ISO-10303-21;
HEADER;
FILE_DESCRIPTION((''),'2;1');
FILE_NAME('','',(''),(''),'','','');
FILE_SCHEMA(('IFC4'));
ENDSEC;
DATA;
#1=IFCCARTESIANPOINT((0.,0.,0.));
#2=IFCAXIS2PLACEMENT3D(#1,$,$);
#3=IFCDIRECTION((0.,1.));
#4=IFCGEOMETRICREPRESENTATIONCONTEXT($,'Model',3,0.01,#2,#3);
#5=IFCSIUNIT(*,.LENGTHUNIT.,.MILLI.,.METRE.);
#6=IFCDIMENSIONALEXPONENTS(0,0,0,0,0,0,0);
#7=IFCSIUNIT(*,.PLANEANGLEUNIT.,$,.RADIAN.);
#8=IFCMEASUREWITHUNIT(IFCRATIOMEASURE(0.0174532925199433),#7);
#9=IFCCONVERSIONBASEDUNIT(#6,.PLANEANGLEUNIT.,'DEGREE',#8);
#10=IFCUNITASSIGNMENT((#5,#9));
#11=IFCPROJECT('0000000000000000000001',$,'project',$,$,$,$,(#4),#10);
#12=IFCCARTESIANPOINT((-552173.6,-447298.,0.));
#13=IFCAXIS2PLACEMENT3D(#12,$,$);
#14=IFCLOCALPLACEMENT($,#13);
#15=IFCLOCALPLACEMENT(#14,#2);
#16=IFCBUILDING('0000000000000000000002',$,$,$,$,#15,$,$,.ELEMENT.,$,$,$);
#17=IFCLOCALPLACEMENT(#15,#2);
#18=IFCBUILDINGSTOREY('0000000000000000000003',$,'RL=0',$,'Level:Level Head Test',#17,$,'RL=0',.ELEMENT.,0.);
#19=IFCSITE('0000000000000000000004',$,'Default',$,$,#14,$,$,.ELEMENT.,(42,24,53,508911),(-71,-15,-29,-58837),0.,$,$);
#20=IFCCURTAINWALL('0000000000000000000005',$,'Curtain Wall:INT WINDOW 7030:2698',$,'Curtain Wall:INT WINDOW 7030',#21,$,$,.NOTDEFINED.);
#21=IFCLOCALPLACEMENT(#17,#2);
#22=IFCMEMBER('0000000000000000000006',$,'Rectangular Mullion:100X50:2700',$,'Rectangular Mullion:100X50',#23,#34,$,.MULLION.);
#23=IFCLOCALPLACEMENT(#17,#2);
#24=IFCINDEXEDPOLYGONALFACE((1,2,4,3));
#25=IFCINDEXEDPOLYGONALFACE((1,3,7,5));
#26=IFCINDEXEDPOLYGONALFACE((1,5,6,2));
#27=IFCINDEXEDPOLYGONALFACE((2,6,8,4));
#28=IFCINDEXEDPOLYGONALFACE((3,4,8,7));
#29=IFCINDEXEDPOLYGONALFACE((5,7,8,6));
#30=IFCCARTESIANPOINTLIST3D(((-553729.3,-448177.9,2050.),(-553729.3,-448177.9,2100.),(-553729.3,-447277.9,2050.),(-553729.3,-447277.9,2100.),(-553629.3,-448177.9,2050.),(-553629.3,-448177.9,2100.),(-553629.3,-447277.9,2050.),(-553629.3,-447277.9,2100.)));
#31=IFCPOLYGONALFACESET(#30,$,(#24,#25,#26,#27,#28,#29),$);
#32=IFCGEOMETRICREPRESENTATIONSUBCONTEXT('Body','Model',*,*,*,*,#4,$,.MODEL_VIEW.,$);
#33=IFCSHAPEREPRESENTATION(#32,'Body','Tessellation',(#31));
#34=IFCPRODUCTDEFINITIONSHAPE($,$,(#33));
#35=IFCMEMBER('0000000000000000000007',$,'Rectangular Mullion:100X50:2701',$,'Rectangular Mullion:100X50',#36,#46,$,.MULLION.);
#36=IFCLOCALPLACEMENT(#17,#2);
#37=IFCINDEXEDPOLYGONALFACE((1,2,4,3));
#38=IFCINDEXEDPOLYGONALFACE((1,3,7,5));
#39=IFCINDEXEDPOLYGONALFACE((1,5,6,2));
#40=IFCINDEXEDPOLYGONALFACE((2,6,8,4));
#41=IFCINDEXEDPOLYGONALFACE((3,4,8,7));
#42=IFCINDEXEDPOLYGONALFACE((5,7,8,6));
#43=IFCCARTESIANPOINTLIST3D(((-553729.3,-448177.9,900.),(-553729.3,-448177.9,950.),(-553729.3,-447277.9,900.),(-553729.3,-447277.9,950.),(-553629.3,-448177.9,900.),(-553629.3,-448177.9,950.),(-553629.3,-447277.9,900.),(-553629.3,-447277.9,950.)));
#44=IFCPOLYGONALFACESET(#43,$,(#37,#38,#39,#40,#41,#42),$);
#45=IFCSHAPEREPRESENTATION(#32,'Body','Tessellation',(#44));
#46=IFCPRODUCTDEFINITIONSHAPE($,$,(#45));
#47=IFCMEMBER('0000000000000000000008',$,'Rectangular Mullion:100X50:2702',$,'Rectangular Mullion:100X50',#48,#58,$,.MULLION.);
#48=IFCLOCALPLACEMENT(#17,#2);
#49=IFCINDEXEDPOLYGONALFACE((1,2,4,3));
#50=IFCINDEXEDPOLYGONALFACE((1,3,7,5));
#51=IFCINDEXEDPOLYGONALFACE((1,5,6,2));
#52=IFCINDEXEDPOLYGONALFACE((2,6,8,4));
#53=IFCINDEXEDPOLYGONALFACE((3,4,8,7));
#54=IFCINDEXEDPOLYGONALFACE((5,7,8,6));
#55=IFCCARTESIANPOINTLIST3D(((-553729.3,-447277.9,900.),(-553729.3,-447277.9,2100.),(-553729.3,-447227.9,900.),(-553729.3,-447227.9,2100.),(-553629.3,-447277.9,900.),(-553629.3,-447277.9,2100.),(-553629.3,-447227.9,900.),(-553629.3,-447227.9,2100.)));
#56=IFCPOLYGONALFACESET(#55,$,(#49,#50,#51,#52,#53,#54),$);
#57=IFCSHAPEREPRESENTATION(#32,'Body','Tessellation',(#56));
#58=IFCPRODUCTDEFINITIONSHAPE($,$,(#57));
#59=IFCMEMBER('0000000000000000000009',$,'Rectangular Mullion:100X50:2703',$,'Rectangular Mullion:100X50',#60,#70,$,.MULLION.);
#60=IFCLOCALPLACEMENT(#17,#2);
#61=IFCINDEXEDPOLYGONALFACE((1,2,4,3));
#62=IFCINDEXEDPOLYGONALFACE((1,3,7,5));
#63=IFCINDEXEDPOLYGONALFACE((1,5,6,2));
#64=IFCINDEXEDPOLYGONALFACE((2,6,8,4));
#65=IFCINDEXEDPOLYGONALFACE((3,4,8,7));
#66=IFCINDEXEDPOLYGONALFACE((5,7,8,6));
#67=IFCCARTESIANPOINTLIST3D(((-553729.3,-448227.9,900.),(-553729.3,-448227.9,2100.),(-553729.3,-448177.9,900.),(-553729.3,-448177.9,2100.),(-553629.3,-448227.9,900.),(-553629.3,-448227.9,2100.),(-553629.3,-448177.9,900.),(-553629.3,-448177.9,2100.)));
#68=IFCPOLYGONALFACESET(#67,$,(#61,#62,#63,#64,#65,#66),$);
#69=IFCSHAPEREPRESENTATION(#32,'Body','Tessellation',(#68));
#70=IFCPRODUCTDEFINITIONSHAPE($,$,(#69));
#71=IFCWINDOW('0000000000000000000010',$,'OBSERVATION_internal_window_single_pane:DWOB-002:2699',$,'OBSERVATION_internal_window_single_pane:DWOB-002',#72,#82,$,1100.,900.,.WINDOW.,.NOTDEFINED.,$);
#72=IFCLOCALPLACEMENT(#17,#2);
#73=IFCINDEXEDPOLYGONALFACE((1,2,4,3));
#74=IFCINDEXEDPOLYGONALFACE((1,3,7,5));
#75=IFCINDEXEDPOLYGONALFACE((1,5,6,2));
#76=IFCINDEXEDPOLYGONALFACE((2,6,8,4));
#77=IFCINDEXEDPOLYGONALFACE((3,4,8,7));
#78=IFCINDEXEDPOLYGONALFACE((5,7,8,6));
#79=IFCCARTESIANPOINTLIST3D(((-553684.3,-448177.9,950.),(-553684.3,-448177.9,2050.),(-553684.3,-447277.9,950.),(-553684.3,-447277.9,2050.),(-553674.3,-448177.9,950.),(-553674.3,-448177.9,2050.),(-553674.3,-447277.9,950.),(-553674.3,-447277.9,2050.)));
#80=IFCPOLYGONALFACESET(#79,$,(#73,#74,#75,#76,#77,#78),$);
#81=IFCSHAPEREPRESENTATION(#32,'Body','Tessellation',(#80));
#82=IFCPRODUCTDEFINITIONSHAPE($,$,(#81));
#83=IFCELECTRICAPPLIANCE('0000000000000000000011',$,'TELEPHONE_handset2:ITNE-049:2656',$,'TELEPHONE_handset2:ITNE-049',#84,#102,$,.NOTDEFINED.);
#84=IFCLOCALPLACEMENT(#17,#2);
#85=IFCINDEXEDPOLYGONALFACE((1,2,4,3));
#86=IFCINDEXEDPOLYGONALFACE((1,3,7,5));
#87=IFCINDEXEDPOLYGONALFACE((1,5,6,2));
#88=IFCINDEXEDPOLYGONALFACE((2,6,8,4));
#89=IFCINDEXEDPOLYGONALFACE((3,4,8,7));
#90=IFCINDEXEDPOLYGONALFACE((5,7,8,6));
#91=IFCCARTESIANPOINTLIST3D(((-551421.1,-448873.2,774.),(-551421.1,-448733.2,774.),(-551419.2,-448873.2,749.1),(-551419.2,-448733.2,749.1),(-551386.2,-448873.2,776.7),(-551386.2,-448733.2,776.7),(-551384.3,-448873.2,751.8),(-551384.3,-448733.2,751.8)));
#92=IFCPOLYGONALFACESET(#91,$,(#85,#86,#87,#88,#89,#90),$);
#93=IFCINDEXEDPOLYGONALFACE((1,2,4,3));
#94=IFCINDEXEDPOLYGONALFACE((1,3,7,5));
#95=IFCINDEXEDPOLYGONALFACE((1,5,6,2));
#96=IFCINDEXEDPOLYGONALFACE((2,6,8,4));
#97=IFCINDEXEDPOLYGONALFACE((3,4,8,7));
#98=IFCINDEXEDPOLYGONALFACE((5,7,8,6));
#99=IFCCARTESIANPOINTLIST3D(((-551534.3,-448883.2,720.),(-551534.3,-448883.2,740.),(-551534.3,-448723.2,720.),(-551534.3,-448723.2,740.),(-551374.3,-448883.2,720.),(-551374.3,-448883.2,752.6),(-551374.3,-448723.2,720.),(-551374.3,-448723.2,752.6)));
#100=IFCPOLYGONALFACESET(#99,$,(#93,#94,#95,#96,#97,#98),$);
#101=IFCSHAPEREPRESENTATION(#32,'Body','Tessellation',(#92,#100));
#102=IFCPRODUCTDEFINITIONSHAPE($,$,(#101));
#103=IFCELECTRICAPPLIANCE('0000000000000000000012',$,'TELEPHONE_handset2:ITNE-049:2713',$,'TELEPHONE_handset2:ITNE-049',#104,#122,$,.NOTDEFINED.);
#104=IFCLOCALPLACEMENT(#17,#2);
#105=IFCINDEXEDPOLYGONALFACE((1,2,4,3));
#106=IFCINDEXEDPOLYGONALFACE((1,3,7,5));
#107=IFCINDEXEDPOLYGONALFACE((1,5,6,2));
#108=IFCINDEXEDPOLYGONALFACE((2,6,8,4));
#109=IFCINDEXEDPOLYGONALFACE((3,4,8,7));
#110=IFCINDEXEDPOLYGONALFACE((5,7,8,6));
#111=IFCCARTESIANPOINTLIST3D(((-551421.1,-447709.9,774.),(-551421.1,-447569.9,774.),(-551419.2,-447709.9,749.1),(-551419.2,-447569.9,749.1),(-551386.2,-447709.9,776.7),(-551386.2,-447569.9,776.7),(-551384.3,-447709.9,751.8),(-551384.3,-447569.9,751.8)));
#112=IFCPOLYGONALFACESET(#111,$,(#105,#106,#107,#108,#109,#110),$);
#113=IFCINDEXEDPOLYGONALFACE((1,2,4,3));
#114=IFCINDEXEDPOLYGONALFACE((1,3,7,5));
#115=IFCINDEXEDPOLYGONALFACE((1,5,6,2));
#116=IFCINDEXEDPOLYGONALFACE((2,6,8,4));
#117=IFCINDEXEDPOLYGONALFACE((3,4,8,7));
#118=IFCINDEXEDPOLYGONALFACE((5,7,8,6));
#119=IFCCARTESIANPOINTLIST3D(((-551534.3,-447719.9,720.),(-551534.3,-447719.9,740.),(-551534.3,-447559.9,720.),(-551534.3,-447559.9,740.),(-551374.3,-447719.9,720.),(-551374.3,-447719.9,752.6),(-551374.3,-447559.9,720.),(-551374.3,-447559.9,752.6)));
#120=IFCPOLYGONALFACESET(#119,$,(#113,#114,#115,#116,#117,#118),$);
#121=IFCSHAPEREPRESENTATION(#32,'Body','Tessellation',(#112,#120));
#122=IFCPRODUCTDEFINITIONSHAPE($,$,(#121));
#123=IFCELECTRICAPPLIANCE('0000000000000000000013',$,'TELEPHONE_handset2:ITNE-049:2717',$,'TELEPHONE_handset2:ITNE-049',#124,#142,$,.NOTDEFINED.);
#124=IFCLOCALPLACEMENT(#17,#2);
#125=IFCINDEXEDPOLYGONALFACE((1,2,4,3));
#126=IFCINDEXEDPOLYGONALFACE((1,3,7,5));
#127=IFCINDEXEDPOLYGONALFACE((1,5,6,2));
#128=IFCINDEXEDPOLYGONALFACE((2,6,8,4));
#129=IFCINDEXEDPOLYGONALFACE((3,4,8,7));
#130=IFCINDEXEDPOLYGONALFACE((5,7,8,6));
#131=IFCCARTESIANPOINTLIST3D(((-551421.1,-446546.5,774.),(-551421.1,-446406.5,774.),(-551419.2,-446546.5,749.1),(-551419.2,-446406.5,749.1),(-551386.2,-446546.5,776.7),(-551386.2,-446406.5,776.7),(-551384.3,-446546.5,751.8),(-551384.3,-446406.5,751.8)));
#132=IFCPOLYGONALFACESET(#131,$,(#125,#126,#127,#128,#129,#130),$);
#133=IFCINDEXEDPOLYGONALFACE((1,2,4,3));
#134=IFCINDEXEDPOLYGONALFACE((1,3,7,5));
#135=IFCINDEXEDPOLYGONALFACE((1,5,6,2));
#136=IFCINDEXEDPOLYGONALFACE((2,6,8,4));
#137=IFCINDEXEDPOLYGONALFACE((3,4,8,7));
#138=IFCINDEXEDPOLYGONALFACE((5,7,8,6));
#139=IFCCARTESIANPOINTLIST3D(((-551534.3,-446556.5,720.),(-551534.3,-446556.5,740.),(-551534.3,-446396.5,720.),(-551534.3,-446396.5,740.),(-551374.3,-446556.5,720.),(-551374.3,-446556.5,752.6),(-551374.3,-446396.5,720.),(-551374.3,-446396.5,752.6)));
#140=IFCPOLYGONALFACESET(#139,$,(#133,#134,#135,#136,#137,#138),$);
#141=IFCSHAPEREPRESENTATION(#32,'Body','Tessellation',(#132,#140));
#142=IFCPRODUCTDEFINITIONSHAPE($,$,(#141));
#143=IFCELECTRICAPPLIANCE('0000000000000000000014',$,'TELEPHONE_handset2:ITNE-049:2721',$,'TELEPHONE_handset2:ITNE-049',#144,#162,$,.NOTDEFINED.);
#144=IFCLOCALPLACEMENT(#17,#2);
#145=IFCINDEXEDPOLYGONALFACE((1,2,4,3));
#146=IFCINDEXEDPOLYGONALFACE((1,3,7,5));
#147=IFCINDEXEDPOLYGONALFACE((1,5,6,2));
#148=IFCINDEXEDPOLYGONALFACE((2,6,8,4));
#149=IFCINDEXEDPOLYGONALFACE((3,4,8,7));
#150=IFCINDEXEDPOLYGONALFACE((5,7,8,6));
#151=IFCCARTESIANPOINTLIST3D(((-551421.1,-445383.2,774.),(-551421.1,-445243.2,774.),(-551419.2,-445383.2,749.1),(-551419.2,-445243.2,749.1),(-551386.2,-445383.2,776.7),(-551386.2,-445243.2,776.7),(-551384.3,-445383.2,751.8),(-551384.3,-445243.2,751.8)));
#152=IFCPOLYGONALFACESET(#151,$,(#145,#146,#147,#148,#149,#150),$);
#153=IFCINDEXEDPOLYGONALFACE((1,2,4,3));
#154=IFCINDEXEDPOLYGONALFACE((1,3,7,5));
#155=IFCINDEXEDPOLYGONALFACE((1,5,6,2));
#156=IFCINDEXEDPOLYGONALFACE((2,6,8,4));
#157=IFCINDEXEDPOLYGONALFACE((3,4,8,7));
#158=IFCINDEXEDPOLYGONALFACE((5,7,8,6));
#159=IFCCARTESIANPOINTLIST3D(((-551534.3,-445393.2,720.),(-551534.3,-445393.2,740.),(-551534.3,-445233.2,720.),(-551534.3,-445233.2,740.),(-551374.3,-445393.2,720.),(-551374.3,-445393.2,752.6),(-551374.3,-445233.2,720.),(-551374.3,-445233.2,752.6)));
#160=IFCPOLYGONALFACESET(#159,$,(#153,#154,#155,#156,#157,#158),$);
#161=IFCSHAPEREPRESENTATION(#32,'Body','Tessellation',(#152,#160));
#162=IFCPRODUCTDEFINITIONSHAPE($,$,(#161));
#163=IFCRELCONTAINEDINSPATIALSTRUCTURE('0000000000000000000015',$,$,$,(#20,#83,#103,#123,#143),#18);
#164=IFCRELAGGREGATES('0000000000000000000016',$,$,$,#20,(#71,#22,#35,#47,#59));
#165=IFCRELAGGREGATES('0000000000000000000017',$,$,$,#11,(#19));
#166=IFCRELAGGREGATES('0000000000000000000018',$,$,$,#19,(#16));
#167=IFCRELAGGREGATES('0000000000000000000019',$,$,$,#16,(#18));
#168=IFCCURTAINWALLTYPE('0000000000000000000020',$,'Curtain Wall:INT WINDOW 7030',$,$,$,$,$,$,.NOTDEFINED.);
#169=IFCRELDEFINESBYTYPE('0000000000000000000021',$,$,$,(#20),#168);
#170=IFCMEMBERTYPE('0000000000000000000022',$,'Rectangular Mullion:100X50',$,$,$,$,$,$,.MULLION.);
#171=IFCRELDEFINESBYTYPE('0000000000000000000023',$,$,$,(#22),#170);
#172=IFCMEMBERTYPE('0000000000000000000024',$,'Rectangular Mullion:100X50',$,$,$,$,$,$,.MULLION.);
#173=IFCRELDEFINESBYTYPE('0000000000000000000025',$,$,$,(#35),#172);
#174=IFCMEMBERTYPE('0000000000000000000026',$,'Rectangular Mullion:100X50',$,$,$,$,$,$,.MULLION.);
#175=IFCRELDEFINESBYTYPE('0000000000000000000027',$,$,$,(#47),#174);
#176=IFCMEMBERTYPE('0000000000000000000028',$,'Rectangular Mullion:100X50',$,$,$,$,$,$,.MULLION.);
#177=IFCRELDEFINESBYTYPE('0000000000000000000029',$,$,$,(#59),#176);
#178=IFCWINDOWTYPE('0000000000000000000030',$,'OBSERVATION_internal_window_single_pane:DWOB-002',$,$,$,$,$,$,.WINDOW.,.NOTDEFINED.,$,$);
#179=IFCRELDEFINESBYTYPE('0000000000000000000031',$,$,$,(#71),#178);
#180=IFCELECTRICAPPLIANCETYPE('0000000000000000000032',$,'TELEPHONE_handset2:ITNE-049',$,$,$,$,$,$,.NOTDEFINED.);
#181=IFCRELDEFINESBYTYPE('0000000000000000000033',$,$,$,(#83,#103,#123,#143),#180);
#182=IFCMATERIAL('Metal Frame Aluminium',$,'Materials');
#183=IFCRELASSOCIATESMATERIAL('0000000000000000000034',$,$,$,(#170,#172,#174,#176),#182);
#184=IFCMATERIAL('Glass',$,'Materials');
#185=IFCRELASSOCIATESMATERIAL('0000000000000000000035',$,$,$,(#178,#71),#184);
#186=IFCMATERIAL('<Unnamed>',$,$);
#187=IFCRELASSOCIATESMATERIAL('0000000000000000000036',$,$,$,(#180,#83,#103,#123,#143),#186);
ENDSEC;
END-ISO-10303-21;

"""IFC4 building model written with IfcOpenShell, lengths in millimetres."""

from ifc_helpers import new_model, entity, si_unit, converted_unit, direction, frame, origin, place, context, subcontext, project, spatial, indexed_curve, outline, extrude, source, transform, mapped, material, type_object, type_shapes, element, aggregate, save


model = new_model("IFC4")

# Units and contexts
model_context = context("Model", 3, precision=0.01, world=origin(), true_north=direction((0.0, 1.0)))
body_context = subcontext(model_context, "Body", "Model", "MODEL_VIEW")
ifc_project = project(units=[si_unit("LENGTHUNIT", "METRE", prefix="MILLI"), converted_unit("PLANEANGLEUNIT", "DEGREE", entity("IfcRatioMeasure", 0.0174532925199433), si_unit("PLANEANGLEUNIT", "RADIAN"), dimensions=[0, 0, 0, 0, 0, 0, 0])], contexts=[model_context])

# Site, building, storey
site_placement = place(None, frame((-552173.6, -447298.0, 0.0)))
site = spatial("IfcSite", under=ifc_project, at=site_placement, Name="Default", CompositionType="ELEMENT", RefLatitude=(42, 24, 53, 508911), RefLongitude=(-71, -15, -29, -58837), RefElevation=0.0)
building_placement = place(site_placement, origin())
building = spatial("IfcBuilding", under=site, at=building_placement, CompositionType="ELEMENT")
storey_placement = place(building_placement, origin())
storey = spatial("IfcBuildingStorey", under=building, at=storey_placement, Name="RL=0", ObjectType="Level:Level Head Test", LongName="RL=0", CompositionType="ELEMENT", Elevation=0.0)

# Curtain wall, members
curtain_wall_type = type_object("IfcCurtainWallType", Name="Curtain Wall:INT WINDOW 7030", PredefinedType="NOTDEFINED")
curtain_wall_placement = place(storey_placement, origin())
curtain_wall = element("IfcCurtainWall", 1, at=curtain_wall_placement, inside=storey, type_object=curtain_wall_type, Name="Curtain Wall:INT WINDOW 7030:2698", ObjectType="Curtain Wall:INT WINDOW 7030", PredefinedType="NOTDEFINED")
ifc_material_1 = material(Name="Metal Frame Aluminium", Category="Materials")
member_type_1 = type_object("IfcMemberType", Name="Rectangular Mullion:100X50", PredefinedType="MULLION", material=ifc_material_1)
shared_shape_1 = source(origin(), body_context, "Body", "SweptSolid", [
    extrude(outline(indexed_curve([(-50.0, -25.0), (50.0, -25.0), (50.0, 25.0), (-50.0, 25.0), (-50.0, -25.0)], self_intersect=False)), frame((-25.0, 0.0, -900.0), z_axis=(0.0, 0.0, 1.0), x_axis=(0.0, -1.0, 0.0)), (0.0, 0.0, 1.0), 900.0),
])
type_shapes(member_type_1, [shared_shape_1])
member_1_placement = place(curtain_wall_placement, frame((-553679.3, -447277.9, 2100.0), z_axis=(0.0, 1.0, 0.0), x_axis=(0.0, 0.0, 1.0)))
member_1 = element("IfcMember", 2, at=member_1_placement, type_object=member_type_1, Name="Rectangular Mullion:100X50:2700", ObjectType="Rectangular Mullion:100X50", PredefinedType="MULLION", context=body_context, shape_type="MappedRepresentation", body=[
    mapped(shared_shape_1, transform((0.0, 0.0, 0.0), scale=1.0)),
])
member_type_2 = type_object("IfcMemberType", Name="Rectangular Mullion:100X50", PredefinedType="MULLION", material=ifc_material_1)
shared_shape_2 = source(origin(), body_context, "Body", "SweptSolid", [
    extrude(outline(indexed_curve([(-50.0, -25.0), (50.0, -25.0), (50.0, 25.0), (-50.0, 25.0), (-50.0, -25.0)], self_intersect=False)), frame((-25.0, 0.0, -900.0), z_axis=(0.0, 0.0, 1.0), x_axis=(0.0, -1.0, 0.0)), (0.0, 0.0, 1.0), 900.0),
])
type_shapes(member_type_2, [shared_shape_2])
member_2_placement = place(curtain_wall_placement, frame((-553679.3, -448177.9, 900.0), z_axis=(0.0, -1.0, 0.0), x_axis=(0.0, 0.0, -1.0)))
member_2 = element("IfcMember", 3, at=member_2_placement, type_object=member_type_2, Name="Rectangular Mullion:100X50:2701", ObjectType="Rectangular Mullion:100X50", PredefinedType="MULLION", context=body_context, shape_type="MappedRepresentation", body=[
    mapped(shared_shape_2, transform((0.0, 0.0, 0.0), scale=1.0)),
])
member_type_3 = type_object("IfcMemberType", Name="Rectangular Mullion:100X50", PredefinedType="MULLION", material=ifc_material_1)
shared_shape_3 = source(origin(), body_context, "Body", "SweptSolid", [
    extrude(outline(indexed_curve([(-50.0, -25.0), (50.0, -25.0), (50.0, 25.0), (-50.0, 25.0), (-50.0, -25.0)], self_intersect=False)), frame((-25.0, 0.0, -1200.0), z_axis=(0.0, 0.0, 1.0), x_axis=(0.0, -1.0, 0.0)), (0.0, 0.0, 1.0), 1200.0),
])
type_shapes(member_type_3, [shared_shape_3])
member_3_placement = place(curtain_wall_placement, frame((-553679.3, -447227.9, 900.0), z_axis=(0.0, 0.0, -1.0), x_axis=(0.0, 1.0, 0.0)))
member_3 = element("IfcMember", 4, at=member_3_placement, type_object=member_type_3, Name="Rectangular Mullion:100X50:2702", ObjectType="Rectangular Mullion:100X50", PredefinedType="MULLION", context=body_context, shape_type="MappedRepresentation", body=[
    mapped(shared_shape_3, transform((0.0, 0.0, 0.0), scale=1.0)),
])
member_type_4 = type_object("IfcMemberType", Name="Rectangular Mullion:100X50", PredefinedType="MULLION", material=ifc_material_1)
shared_shape_4 = source(origin(), body_context, "Body", "SweptSolid", [
    extrude(outline(indexed_curve([(-50.0, -25.0), (50.0, -25.0), (50.0, 25.0), (-50.0, 25.0), (-50.0, -25.0)], self_intersect=False)), frame((-25.0, 0.0, -1200.0), z_axis=(0.0, 0.0, 1.0), x_axis=(0.0, -1.0, 0.0)), (0.0, 0.0, 1.0), 1200.0),
])
type_shapes(member_type_4, [shared_shape_4])
member_4_placement = place(curtain_wall_placement, frame((-553679.3, -448227.9, 2100.0), z_axis=(0.0, 0.0, 1.0), x_axis=(0.0, -1.0, 0.0)))
member_4 = element("IfcMember", 5, at=member_4_placement, type_object=member_type_4, Name="Rectangular Mullion:100X50:2703", ObjectType="Rectangular Mullion:100X50", PredefinedType="MULLION", context=body_context, shape_type="MappedRepresentation", body=[
    mapped(shared_shape_4, transform((0.0, 0.0, 0.0), scale=1.0)),
])

# Window
ifc_material_2 = material(Name="Glass", Category="Materials")
window_type = type_object("IfcWindowType", Name="OBSERVATION_internal_window_single_pane:DWOB-002", PartitioningType="NOTDEFINED", PredefinedType="WINDOW", material=ifc_material_2)
shared_shape_5 = source(origin(), body_context, "Body", "SweptSolid", [
    extrude(outline(indexed_curve([(-5.0, -450.0), (5.0, -450.0), (5.0, 450.0), (-5.0, 450.0), (-5.0, -450.0)], self_intersect=False)), frame((0.0, 0.0, 0.0), z_axis=(0.0, 0.0, 1.0), x_axis=(0.0, 1.0, 0.0)), (0.0, 0.0, 1.0), 1100.0),
])
type_shapes(window_type, [shared_shape_5])
window_placement = place(curtain_wall_placement, frame((-553679.3, -447727.9, 950.0), z_axis=(0.0, 0.0, 1.0), x_axis=(0.0, 1.0, 0.0)))
window = element("IfcWindow", 6, at=window_placement, type_object=window_type, material=ifc_material_2, Name="OBSERVATION_internal_window_single_pane:DWOB-002:2699", ObjectType="OBSERVATION_internal_window_single_pane:DWOB-002", OverallHeight=1100.0, OverallWidth=900.0, PartitioningType="NOTDEFINED", PredefinedType="WINDOW", context=body_context, shape_type="MappedRepresentation", body=[
    mapped(shared_shape_5, transform((0.0, 0.0, 0.0), scale=1.0)),
])
aggregate(curtain_wall, [window, member_1, member_2, member_3, member_4])

# Electric appliances
ifc_material_3 = material(Name="<Unnamed>")
electric_appliance_type_1 = type_object("IfcElectricApplianceType", Name="TELEPHONE_handset2:ITNE-049", PredefinedType="NOTDEFINED", material=ifc_material_3)
shared_shape_6 = source(origin(), body_context, "Body", "SweptSolid", [
    extrude(outline(indexed_curve([(-12.5, -17.5), (12.5, -17.5), (12.5, 17.5), (-12.5, 17.5), (-12.5, -17.5)], self_intersect=False)), frame((-70.0, 51.6, 42.9), z_axis=(1.0, 0.0, 0.0), x_axis=(0.0, 0.078584, -0.996907)), (0.0, 0.0, 1.0), 140.0),
    extrude(outline(indexed_curve([(-80.0, -13.2), (80.0, -13.2), (80.0, 19.5), (-80.0, 6.8), (-80.0, -13.2)], self_intersect=False)), frame((-80.0, 0.0, 13.2), z_axis=(1.0, 0.0, 0.0), x_axis=(0.0, 1.0, 0.0)), (0.0, 0.0, 1.0), 160.0),
])
type_shapes(electric_appliance_type_1, [shared_shape_6])
for number, where, z_axis, x_axis, name in (
    (7, (-551454.3, -448803.2, 720.0), (0.0, 0.0, 1.0), (0.0, -1.0, 0.0), "TELEPHONE_handset2:ITNE-049:2656"),
    (8, (-551454.3, -447639.9, 720.0), (0.0, 0.0, 1.0), (0.0, -1.0, 0.0), "TELEPHONE_handset2:ITNE-049:2713"),
    (9, (-551454.3, -446476.5, 720.0), (0.0, 0.0, 1.0), (0.0, -1.0, 0.0), "TELEPHONE_handset2:ITNE-049:2717"),
    (10, (-551454.3, -445313.2, 720.0), (0.0, 0.0, 1.0), (0.0, -1.0, 0.0), "TELEPHONE_handset2:ITNE-049:2721"),
):
    element("IfcElectricAppliance", number, at=place(storey_placement, frame(where, z_axis=z_axis, x_axis=x_axis)), inside=storey, type_object=electric_appliance_type_1, material=ifc_material_3, Name=name, ObjectType="TELEPHONE_handset2:ITNE-049", PredefinedType="NOTDEFINED", context=body_context, shape_type="MappedRepresentation", body=[
        mapped(shared_shape_6, transform((0.0, 0.0, 0.0), scale=1.0)),
    ])

save(model, "model.ifc")
